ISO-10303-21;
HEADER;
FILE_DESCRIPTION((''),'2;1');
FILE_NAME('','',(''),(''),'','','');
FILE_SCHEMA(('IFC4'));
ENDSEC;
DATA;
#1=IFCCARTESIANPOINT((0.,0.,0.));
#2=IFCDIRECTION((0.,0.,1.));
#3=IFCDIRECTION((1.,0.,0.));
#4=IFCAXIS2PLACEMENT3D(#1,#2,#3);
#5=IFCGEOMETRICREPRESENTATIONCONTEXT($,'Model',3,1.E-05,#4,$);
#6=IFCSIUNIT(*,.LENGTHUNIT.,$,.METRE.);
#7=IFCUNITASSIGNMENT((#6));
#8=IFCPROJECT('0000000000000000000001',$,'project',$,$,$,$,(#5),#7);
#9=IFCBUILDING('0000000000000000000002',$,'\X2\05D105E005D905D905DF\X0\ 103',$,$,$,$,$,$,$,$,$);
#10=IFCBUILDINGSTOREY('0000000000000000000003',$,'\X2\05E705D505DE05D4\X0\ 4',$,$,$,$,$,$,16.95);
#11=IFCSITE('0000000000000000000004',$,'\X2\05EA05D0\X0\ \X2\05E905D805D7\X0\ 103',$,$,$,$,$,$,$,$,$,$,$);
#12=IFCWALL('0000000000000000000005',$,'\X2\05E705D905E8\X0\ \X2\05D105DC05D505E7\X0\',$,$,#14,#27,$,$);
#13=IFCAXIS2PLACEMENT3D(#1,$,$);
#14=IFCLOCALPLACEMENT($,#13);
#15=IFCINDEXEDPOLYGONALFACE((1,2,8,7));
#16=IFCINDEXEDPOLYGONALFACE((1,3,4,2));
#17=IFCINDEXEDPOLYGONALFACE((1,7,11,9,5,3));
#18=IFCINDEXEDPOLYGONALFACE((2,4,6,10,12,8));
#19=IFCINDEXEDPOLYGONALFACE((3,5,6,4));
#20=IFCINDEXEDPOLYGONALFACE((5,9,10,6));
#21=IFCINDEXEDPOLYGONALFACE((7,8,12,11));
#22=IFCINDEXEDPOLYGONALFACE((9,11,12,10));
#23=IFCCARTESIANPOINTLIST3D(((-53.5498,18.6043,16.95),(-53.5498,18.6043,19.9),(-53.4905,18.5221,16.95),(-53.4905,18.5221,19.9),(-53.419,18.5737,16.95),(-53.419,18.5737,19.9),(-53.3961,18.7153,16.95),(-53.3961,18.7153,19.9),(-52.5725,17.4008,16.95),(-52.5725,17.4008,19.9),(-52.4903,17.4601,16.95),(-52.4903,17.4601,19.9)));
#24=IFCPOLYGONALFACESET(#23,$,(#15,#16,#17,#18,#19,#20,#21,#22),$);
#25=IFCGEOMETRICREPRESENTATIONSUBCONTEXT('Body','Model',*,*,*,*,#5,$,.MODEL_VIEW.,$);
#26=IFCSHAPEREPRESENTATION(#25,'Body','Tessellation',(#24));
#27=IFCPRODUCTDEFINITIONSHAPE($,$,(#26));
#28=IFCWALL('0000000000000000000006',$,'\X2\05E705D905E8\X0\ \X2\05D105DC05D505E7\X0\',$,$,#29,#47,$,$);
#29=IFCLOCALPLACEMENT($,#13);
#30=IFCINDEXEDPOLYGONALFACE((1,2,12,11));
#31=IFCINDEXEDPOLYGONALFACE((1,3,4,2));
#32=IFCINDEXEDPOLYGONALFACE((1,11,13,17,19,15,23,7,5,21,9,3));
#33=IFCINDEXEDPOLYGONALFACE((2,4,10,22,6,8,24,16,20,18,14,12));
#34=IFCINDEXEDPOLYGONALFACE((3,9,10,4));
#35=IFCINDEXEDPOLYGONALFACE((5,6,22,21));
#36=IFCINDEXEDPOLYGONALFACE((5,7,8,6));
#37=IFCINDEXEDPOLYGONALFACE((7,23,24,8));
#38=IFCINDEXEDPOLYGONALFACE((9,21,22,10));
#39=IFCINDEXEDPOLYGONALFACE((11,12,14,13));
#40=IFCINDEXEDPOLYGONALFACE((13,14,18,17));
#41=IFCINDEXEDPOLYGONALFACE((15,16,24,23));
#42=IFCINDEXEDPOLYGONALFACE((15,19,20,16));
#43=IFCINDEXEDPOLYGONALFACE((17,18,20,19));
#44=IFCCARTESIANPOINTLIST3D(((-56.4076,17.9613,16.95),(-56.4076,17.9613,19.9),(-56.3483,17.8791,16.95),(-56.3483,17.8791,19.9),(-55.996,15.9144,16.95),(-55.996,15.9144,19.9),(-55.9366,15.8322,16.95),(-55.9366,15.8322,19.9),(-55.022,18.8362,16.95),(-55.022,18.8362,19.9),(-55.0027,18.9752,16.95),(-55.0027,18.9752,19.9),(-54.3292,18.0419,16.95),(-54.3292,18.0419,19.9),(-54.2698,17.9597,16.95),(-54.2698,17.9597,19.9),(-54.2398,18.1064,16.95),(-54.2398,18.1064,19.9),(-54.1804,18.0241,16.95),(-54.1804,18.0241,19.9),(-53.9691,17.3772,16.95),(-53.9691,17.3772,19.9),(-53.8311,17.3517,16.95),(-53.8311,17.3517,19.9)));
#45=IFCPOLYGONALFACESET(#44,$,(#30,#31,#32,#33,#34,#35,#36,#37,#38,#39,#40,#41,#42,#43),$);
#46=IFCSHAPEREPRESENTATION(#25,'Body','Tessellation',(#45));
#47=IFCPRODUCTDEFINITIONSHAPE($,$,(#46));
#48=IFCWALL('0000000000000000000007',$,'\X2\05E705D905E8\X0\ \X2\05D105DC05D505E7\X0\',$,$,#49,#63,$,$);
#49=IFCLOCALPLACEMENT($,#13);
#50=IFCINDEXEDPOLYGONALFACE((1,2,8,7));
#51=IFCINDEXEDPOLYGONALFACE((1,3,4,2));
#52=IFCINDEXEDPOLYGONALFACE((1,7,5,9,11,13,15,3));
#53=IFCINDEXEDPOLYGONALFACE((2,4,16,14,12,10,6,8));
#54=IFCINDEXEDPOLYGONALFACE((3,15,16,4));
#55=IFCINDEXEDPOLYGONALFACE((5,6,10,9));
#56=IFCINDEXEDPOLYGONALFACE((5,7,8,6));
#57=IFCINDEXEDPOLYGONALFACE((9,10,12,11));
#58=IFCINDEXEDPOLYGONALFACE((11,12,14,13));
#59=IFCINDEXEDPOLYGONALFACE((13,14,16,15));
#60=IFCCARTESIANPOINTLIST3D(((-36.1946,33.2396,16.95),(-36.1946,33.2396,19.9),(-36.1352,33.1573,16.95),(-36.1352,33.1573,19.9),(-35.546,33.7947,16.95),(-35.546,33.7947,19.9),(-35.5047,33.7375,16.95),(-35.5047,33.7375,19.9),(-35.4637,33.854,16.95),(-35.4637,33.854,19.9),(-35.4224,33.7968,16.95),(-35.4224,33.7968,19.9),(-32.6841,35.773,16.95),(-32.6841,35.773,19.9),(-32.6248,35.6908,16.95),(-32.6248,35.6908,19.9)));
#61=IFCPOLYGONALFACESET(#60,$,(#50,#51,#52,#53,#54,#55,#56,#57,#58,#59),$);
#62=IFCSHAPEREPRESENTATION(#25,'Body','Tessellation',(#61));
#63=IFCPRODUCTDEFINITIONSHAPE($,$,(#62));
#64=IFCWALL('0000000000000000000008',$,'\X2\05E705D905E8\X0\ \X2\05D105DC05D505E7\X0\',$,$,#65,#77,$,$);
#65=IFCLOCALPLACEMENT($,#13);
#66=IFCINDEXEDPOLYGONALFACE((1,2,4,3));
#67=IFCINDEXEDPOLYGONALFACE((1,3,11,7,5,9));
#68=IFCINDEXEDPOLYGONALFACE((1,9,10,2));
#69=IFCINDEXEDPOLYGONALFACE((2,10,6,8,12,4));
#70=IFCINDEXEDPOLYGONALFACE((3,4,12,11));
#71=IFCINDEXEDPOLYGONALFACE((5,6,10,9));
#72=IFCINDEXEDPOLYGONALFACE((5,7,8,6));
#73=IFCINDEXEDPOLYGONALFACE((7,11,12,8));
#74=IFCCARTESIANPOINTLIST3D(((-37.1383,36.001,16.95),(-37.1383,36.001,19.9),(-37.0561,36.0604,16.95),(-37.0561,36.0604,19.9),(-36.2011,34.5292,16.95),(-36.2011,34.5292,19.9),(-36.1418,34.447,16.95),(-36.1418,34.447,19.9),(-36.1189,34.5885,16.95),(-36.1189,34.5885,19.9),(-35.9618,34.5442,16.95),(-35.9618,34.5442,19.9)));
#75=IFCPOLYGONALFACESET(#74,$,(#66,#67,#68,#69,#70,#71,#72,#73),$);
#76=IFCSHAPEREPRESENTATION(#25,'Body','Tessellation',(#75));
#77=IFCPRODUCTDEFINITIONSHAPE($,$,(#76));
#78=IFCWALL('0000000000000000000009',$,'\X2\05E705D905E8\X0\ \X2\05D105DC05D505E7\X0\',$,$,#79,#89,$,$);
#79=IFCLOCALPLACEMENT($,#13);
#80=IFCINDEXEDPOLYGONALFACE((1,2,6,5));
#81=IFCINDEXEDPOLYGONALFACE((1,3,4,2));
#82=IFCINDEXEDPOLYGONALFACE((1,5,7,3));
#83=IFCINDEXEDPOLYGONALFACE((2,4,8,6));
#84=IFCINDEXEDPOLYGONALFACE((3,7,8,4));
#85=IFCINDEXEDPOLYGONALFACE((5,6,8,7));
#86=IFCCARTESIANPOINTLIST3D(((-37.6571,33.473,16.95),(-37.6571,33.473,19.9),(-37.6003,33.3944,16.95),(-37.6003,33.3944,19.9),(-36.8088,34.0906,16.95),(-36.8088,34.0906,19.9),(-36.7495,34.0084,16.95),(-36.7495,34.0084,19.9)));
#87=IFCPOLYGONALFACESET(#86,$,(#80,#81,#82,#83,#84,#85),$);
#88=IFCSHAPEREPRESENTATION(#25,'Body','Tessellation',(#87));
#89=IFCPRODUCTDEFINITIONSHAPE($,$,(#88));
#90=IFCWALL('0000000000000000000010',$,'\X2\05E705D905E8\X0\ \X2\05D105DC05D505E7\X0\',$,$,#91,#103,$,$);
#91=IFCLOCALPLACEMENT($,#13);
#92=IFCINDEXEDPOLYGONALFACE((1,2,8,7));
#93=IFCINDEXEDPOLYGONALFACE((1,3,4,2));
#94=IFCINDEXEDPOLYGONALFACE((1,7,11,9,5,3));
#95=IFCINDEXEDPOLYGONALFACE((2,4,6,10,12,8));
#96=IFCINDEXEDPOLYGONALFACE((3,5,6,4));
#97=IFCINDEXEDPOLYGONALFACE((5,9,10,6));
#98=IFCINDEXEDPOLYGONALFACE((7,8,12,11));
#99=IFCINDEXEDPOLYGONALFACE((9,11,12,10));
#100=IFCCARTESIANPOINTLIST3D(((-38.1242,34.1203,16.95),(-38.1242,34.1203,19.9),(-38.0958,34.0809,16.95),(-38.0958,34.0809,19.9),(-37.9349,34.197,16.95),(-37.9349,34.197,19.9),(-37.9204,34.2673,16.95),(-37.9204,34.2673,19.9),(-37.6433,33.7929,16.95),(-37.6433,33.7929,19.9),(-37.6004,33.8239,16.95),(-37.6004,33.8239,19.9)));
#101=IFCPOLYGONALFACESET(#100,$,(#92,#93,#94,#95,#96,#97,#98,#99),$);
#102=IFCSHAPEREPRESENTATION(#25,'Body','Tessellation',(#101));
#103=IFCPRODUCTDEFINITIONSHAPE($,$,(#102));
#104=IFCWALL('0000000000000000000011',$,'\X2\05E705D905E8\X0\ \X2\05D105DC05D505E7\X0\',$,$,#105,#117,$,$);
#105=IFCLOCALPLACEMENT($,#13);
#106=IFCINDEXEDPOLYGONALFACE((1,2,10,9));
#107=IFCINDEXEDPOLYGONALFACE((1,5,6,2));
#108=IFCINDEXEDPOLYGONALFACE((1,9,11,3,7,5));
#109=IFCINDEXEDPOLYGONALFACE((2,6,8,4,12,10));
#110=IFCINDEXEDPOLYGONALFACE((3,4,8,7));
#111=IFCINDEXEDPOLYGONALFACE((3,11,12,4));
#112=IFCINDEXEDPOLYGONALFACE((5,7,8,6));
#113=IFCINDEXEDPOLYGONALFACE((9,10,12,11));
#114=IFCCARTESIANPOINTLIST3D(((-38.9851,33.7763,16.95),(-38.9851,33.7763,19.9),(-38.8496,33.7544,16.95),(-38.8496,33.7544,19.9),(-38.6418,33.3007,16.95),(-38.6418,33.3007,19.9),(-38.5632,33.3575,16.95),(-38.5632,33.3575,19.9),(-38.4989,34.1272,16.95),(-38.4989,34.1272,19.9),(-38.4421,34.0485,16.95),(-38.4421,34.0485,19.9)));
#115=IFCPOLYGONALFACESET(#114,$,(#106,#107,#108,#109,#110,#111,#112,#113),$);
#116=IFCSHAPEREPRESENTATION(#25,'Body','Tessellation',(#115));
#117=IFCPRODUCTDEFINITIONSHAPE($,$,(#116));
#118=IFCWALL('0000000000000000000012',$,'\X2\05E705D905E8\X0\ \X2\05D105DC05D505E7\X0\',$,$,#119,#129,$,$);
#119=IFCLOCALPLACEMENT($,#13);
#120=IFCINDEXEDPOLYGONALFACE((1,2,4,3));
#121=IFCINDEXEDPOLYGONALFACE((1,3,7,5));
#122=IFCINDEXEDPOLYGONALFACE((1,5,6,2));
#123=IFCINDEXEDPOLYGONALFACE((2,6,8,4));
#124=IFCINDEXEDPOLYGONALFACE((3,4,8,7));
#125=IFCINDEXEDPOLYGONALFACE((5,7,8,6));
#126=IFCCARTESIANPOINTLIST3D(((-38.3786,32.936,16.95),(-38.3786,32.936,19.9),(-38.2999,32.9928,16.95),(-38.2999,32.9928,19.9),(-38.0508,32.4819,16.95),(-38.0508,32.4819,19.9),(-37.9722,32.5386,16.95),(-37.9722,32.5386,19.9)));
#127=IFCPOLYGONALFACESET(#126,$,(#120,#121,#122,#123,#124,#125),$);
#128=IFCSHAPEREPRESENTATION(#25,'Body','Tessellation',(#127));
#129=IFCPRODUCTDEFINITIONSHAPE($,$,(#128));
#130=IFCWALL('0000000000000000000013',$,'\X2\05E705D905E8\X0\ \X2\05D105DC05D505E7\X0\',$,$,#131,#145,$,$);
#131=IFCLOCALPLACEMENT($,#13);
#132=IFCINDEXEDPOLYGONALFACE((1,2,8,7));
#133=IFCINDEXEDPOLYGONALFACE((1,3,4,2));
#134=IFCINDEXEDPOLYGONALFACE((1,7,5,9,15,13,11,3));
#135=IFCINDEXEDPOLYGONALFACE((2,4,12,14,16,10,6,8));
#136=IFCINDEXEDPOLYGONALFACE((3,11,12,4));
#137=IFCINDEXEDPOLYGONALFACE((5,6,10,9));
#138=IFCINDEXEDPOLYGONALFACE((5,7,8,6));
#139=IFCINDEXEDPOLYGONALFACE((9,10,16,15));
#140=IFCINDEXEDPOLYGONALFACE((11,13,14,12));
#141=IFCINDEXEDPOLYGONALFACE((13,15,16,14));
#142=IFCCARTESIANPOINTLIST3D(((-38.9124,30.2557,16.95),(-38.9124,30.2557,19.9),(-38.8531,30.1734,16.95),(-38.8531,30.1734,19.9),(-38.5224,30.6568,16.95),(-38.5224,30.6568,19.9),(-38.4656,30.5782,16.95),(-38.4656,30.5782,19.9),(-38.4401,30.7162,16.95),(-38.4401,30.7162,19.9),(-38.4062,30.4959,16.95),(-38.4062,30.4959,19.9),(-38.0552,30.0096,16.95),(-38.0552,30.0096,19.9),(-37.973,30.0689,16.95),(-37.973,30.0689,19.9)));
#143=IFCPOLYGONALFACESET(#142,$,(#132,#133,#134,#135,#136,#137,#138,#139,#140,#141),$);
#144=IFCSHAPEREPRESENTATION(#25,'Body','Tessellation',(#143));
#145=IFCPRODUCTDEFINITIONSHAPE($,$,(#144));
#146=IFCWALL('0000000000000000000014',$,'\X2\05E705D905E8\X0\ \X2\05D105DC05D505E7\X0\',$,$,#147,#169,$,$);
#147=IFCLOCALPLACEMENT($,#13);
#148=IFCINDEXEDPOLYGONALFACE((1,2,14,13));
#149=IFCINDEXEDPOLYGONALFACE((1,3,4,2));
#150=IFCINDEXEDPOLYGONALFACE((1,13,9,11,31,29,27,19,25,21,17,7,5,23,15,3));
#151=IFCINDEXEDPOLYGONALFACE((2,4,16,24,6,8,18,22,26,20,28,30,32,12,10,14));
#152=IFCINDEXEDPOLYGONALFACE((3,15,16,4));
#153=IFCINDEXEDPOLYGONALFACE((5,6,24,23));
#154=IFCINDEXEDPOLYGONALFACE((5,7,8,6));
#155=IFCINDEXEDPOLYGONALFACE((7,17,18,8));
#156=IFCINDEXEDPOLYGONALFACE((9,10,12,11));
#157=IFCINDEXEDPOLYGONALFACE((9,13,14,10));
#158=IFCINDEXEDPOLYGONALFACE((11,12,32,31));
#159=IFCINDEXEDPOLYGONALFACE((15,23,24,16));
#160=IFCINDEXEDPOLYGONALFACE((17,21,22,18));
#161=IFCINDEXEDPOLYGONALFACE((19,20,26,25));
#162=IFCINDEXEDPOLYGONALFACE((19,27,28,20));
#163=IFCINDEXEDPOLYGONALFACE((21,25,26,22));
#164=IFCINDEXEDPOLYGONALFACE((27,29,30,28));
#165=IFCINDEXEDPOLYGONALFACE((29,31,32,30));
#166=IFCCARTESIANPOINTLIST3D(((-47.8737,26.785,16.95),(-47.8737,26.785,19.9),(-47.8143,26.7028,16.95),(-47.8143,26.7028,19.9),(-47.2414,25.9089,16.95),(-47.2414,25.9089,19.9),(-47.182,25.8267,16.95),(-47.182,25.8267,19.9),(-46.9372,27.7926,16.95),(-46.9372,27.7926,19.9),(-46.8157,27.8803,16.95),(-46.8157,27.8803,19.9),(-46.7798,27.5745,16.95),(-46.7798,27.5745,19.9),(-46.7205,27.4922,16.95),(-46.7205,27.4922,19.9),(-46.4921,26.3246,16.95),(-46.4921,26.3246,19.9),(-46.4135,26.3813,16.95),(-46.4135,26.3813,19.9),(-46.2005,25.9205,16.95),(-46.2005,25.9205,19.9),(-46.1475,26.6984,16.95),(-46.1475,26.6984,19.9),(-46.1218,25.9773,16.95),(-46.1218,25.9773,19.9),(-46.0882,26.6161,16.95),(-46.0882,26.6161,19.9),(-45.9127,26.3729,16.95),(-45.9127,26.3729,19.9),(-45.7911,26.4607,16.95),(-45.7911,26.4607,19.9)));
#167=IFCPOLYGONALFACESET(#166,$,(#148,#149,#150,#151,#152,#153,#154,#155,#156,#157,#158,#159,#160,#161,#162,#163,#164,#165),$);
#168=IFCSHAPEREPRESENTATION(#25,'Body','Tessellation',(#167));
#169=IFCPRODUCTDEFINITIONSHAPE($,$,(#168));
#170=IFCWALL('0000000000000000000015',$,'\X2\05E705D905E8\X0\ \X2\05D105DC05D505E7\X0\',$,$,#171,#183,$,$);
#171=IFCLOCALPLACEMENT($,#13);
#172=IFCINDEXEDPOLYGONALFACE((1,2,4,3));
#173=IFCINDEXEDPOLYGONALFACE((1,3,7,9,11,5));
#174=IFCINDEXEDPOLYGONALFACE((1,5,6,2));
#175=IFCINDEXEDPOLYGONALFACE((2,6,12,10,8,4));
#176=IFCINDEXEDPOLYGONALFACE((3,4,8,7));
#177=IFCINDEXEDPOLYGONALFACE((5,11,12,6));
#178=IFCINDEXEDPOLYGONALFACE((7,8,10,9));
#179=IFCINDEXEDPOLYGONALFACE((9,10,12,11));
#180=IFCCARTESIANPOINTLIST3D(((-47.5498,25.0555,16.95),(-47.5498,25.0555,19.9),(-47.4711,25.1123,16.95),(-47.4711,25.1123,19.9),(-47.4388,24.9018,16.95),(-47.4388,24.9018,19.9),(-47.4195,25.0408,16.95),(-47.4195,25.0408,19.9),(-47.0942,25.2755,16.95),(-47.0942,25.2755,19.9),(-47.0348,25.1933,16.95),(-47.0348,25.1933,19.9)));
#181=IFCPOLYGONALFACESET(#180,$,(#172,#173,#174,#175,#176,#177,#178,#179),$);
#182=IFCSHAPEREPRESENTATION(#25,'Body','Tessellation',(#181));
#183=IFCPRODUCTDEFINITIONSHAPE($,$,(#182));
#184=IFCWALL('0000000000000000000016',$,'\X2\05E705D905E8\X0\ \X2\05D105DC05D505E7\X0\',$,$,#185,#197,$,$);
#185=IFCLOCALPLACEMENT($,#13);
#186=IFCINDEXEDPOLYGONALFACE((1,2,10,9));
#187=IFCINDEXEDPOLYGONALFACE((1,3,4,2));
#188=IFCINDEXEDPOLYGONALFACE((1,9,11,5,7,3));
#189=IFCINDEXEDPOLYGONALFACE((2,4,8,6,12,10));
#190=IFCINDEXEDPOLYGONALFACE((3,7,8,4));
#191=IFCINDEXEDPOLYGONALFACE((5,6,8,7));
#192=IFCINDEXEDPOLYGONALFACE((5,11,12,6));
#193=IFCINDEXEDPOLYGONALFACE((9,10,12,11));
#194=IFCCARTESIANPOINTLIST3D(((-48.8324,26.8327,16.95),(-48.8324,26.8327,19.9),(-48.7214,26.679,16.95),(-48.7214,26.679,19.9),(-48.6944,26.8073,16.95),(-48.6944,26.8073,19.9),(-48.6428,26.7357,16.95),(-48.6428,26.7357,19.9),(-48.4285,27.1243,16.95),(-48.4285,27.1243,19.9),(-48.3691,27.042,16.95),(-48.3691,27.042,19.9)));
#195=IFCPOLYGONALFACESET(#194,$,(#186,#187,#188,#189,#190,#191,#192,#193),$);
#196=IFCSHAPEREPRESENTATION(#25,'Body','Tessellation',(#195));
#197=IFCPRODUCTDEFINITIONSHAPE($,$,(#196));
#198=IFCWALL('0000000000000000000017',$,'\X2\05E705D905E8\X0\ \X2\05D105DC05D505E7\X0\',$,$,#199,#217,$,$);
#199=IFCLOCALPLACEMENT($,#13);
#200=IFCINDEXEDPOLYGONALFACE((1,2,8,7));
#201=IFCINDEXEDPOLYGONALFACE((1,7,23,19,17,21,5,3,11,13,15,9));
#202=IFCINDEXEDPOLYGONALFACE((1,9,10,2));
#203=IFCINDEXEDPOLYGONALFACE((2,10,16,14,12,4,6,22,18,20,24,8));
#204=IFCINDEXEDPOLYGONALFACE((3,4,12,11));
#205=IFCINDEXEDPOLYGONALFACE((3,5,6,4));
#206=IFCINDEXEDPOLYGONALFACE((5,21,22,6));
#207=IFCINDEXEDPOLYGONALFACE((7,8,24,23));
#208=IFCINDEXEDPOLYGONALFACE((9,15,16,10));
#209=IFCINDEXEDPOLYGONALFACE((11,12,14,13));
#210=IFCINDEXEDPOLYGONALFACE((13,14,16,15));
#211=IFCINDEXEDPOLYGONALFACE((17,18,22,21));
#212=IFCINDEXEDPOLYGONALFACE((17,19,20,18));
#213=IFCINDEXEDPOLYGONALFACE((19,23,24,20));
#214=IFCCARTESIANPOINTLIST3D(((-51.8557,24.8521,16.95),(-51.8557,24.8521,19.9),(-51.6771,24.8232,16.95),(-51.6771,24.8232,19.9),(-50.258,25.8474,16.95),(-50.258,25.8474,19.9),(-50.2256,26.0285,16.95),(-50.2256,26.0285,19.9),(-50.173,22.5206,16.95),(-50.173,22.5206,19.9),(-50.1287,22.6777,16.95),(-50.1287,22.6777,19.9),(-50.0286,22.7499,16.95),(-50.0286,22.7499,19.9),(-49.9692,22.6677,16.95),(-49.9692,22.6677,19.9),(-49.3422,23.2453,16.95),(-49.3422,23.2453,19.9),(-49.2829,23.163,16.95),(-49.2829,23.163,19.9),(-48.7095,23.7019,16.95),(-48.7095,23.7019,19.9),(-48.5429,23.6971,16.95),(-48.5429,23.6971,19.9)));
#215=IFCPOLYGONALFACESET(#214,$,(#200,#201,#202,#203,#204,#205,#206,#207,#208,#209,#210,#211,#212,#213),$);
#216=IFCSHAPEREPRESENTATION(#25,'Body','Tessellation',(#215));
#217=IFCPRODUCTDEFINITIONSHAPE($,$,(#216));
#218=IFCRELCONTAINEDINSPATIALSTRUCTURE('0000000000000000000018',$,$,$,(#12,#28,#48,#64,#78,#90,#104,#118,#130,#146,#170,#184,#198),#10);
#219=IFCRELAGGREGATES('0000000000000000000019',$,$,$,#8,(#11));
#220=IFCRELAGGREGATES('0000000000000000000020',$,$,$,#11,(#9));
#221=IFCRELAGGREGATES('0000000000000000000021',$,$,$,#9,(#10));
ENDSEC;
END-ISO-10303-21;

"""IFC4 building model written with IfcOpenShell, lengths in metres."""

from ifc_helpers import new_model, si_unit, frame, origin_with_axes, context, subcontext, project, spatial, polyline, outline, extrude, element, save


model = new_model("IFC4")

# Units and contexts
model_context = context("Model", 3, precision=1e-05, world=origin_with_axes())
body_context = subcontext(model_context, "Body", "Model", "MODEL_VIEW")
ifc_project = project(units=[si_unit("LENGTHUNIT", "METRE")], contexts=[model_context])

# Site, building, storey
site = spatial("IfcSite", under=ifc_project, Name="תא שטח 103")
building = spatial("IfcBuilding", under=site, Name="בניין 103")
storey = spatial("IfcBuildingStorey", under=building, Name="קומה 4", Elevation=16.95)

# Walls
element("IfcWall", 1, inside=storey, Name="קיר בלוק", context=body_context, shape_type="SweptSolid", body=[
    extrude(outline(polyline([(-53.4905, 18.5221), (-53.5498, 18.6043), (-53.3961, 18.7153), (-52.4903, 17.4601), (-52.5725, 17.4008), (-53.419, 18.5737), (-53.4905, 18.5221)])), frame((0.0, 0.0, 16.95)), (0.0, 0.0, 1.0), 2.95),
])
element("IfcWall", 2, inside=storey, Name="קיר בלוק", context=body_context, shape_type="SweptSolid", body=[
    extrude(outline(polyline([(-53.9691, 17.3772), (-55.022, 18.8362), (-56.3483, 17.8791), (-56.4076, 17.9613), (-55.0027, 18.9752), (-54.3292, 18.0419), (-54.2398, 18.1064), (-54.1804, 18.0241), (-54.2698, 17.9597), (-53.8311, 17.3517), (-55.9366, 15.8322), (-55.996, 15.9144), (-53.9691, 17.3772)])), frame((0.0, 0.0, 16.95)), (0.0, 0.0, 1.0), 2.95),
])
element("IfcWall", 3, inside=storey, Name="קיר בלוק", context=body_context, shape_type="SweptSolid", body=[
    extrude(outline(polyline([(-32.6248, 35.6908), (-36.1352, 33.1573), (-36.1946, 33.2396), (-35.5047, 33.7375), (-35.546, 33.7947), (-35.4637, 33.854), (-35.4224, 33.7968), (-32.6841, 35.773), (-32.6248, 35.6908)])), frame((0.0, 0.0, 16.95)), (0.0, 0.0, 1.0), 2.95),
])
element("IfcWall", 4, inside=storey, Name="קיר בלוק", context=body_context, shape_type="SweptSolid", body=[
    extrude(outline(polyline([(-36.1418, 34.447), (-36.2011, 34.5292), (-36.1189, 34.5885), (-37.1383, 36.001), (-37.0561, 36.0604), (-35.9618, 34.5442), (-36.1418, 34.447)])), frame((0.0, 0.0, 16.95)), (0.0, 0.0, 1.0), 2.95),
])
element("IfcWall", 5, inside=storey, Name="קיר בלוק", context=body_context, shape_type="SweptSolid", body=[
    extrude(outline(polyline([(-37.6003, 33.3944), (-37.6571, 33.473), (-36.8088, 34.0906), (-36.7495, 34.0084), (-37.6003, 33.3944)])), frame((0.0, 0.0, 16.95)), (0.0, 0.0, 1.0), 2.95),
])
element("IfcWall", 6, inside=storey, Name="קיר בלוק", context=body_context, shape_type="SweptSolid", body=[
    extrude(outline(polyline([(-38.1242, 34.1203), (-37.9204, 34.2673), (-37.6004, 33.8239), (-37.6433, 33.7929), (-37.9349, 34.197), (-38.0958, 34.0809), (-38.1242, 34.1203)])), frame((0.0, 0.0, 16.95)), (0.0, 0.0, 1.0), 2.95),
])
element("IfcWall", 7, inside=storey, Name="קיר בלוק", context=body_context, shape_type="SweptSolid", body=[
    extrude(outline(polyline([(-38.5632, 33.3575), (-38.6418, 33.3007), (-38.9851, 33.7763), (-38.4989, 34.1272), (-38.4421, 34.0485), (-38.8496, 33.7544), (-38.5632, 33.3575)])), frame((0.0, 0.0, 16.95)), (0.0, 0.0, 1.0), 2.95),
])
element("IfcWall", 8, inside=storey, Name="קיר בלוק", context=body_context, shape_type="SweptSolid", body=[
    extrude(outline(polyline([(-38.2999, 32.9928), (-37.9722, 32.5386), (-38.0508, 32.4819), (-38.3786, 32.936), (-38.2999, 32.9928)])), frame((0.0, 0.0, 16.95)), (0.0, 0.0, 1.0), 2.95),
])
element("IfcWall", 9, inside=storey, Name="קיר בלוק", context=body_context, shape_type="SweptSolid", body=[
    extrude(outline(polyline([(-38.8531, 30.1734), (-38.9124, 30.2557), (-38.4656, 30.5782), (-38.5224, 30.6568), (-38.4401, 30.7162), (-37.973, 30.0689), (-38.0552, 30.0096), (-38.4062, 30.4959), (-38.8531, 30.1734)])), frame((0.0, 0.0, 16.95)), (0.0, 0.0, 1.0), 2.95),
])
element("IfcWall", 10, inside=storey, Name="קיר בלוק", context=body_context, shape_type="SweptSolid", body=[
    extrude(outline(polyline([(-45.7911, 26.4607), (-45.9127, 26.3729), (-46.0882, 26.6161), (-46.4135, 26.3813), (-46.1218, 25.9773), (-46.2005, 25.9205), (-46.4921, 26.3246), (-47.182, 25.8267), (-47.2414, 25.9089), (-46.1475, 26.6984), (-46.7205, 27.4922), (-47.8143, 26.7028), (-47.8737, 26.785), (-46.7798, 27.5745), (-46.9372, 27.7926), (-46.8157, 27.8803), (-45.7911, 26.4607)])), frame((0.0, 0.0, 16.95)), (0.0, 0.0, 1.0), 2.95),
])
element("IfcWall", 11, inside=storey, Name="קיר בלוק", context=body_context, shape_type="SweptSolid", body=[
    extrude(outline(polyline([(-47.5498, 25.0555), (-47.4711, 25.1123), (-47.4195, 25.0408), (-47.0942, 25.2755), (-47.0348, 25.1933), (-47.4388, 24.9018), (-47.5498, 25.0555)])), frame((0.0, 0.0, 16.95)), (0.0, 0.0, 1.0), 2.95),
])
element("IfcWall", 12, inside=storey, Name="קיר בלוק", context=body_context, shape_type="SweptSolid", body=[
    extrude(outline(polyline([(-48.8324, 26.8327), (-48.4285, 27.1243), (-48.3691, 27.042), (-48.6944, 26.8073), (-48.6428, 26.7357), (-48.7214, 26.679), (-48.8324, 26.8327)])), frame((0.0, 0.0, 16.95)), (0.0, 0.0, 1.0), 2.95),
])
element("IfcWall", 13, inside=storey, Name="קיר בלוק", context=body_context, shape_type="SweptSolid", body=[
    extrude(outline(polyline([(-48.7095, 23.7019), (-50.258, 25.8474), (-51.6771, 24.8232), (-50.1287, 22.6777), (-50.0286, 22.7499), (-49.9692, 22.6677), (-50.173, 22.5206), (-51.8557, 24.8521), (-50.2256, 26.0285), (-48.5429, 23.6971), (-49.2829, 23.163), (-49.3422, 23.2453), (-48.7095, 23.7019)])), frame((0.0, 0.0, 16.95)), (0.0, 0.0, 1.0), 2.95),
])

save(model, "model.ifc")
